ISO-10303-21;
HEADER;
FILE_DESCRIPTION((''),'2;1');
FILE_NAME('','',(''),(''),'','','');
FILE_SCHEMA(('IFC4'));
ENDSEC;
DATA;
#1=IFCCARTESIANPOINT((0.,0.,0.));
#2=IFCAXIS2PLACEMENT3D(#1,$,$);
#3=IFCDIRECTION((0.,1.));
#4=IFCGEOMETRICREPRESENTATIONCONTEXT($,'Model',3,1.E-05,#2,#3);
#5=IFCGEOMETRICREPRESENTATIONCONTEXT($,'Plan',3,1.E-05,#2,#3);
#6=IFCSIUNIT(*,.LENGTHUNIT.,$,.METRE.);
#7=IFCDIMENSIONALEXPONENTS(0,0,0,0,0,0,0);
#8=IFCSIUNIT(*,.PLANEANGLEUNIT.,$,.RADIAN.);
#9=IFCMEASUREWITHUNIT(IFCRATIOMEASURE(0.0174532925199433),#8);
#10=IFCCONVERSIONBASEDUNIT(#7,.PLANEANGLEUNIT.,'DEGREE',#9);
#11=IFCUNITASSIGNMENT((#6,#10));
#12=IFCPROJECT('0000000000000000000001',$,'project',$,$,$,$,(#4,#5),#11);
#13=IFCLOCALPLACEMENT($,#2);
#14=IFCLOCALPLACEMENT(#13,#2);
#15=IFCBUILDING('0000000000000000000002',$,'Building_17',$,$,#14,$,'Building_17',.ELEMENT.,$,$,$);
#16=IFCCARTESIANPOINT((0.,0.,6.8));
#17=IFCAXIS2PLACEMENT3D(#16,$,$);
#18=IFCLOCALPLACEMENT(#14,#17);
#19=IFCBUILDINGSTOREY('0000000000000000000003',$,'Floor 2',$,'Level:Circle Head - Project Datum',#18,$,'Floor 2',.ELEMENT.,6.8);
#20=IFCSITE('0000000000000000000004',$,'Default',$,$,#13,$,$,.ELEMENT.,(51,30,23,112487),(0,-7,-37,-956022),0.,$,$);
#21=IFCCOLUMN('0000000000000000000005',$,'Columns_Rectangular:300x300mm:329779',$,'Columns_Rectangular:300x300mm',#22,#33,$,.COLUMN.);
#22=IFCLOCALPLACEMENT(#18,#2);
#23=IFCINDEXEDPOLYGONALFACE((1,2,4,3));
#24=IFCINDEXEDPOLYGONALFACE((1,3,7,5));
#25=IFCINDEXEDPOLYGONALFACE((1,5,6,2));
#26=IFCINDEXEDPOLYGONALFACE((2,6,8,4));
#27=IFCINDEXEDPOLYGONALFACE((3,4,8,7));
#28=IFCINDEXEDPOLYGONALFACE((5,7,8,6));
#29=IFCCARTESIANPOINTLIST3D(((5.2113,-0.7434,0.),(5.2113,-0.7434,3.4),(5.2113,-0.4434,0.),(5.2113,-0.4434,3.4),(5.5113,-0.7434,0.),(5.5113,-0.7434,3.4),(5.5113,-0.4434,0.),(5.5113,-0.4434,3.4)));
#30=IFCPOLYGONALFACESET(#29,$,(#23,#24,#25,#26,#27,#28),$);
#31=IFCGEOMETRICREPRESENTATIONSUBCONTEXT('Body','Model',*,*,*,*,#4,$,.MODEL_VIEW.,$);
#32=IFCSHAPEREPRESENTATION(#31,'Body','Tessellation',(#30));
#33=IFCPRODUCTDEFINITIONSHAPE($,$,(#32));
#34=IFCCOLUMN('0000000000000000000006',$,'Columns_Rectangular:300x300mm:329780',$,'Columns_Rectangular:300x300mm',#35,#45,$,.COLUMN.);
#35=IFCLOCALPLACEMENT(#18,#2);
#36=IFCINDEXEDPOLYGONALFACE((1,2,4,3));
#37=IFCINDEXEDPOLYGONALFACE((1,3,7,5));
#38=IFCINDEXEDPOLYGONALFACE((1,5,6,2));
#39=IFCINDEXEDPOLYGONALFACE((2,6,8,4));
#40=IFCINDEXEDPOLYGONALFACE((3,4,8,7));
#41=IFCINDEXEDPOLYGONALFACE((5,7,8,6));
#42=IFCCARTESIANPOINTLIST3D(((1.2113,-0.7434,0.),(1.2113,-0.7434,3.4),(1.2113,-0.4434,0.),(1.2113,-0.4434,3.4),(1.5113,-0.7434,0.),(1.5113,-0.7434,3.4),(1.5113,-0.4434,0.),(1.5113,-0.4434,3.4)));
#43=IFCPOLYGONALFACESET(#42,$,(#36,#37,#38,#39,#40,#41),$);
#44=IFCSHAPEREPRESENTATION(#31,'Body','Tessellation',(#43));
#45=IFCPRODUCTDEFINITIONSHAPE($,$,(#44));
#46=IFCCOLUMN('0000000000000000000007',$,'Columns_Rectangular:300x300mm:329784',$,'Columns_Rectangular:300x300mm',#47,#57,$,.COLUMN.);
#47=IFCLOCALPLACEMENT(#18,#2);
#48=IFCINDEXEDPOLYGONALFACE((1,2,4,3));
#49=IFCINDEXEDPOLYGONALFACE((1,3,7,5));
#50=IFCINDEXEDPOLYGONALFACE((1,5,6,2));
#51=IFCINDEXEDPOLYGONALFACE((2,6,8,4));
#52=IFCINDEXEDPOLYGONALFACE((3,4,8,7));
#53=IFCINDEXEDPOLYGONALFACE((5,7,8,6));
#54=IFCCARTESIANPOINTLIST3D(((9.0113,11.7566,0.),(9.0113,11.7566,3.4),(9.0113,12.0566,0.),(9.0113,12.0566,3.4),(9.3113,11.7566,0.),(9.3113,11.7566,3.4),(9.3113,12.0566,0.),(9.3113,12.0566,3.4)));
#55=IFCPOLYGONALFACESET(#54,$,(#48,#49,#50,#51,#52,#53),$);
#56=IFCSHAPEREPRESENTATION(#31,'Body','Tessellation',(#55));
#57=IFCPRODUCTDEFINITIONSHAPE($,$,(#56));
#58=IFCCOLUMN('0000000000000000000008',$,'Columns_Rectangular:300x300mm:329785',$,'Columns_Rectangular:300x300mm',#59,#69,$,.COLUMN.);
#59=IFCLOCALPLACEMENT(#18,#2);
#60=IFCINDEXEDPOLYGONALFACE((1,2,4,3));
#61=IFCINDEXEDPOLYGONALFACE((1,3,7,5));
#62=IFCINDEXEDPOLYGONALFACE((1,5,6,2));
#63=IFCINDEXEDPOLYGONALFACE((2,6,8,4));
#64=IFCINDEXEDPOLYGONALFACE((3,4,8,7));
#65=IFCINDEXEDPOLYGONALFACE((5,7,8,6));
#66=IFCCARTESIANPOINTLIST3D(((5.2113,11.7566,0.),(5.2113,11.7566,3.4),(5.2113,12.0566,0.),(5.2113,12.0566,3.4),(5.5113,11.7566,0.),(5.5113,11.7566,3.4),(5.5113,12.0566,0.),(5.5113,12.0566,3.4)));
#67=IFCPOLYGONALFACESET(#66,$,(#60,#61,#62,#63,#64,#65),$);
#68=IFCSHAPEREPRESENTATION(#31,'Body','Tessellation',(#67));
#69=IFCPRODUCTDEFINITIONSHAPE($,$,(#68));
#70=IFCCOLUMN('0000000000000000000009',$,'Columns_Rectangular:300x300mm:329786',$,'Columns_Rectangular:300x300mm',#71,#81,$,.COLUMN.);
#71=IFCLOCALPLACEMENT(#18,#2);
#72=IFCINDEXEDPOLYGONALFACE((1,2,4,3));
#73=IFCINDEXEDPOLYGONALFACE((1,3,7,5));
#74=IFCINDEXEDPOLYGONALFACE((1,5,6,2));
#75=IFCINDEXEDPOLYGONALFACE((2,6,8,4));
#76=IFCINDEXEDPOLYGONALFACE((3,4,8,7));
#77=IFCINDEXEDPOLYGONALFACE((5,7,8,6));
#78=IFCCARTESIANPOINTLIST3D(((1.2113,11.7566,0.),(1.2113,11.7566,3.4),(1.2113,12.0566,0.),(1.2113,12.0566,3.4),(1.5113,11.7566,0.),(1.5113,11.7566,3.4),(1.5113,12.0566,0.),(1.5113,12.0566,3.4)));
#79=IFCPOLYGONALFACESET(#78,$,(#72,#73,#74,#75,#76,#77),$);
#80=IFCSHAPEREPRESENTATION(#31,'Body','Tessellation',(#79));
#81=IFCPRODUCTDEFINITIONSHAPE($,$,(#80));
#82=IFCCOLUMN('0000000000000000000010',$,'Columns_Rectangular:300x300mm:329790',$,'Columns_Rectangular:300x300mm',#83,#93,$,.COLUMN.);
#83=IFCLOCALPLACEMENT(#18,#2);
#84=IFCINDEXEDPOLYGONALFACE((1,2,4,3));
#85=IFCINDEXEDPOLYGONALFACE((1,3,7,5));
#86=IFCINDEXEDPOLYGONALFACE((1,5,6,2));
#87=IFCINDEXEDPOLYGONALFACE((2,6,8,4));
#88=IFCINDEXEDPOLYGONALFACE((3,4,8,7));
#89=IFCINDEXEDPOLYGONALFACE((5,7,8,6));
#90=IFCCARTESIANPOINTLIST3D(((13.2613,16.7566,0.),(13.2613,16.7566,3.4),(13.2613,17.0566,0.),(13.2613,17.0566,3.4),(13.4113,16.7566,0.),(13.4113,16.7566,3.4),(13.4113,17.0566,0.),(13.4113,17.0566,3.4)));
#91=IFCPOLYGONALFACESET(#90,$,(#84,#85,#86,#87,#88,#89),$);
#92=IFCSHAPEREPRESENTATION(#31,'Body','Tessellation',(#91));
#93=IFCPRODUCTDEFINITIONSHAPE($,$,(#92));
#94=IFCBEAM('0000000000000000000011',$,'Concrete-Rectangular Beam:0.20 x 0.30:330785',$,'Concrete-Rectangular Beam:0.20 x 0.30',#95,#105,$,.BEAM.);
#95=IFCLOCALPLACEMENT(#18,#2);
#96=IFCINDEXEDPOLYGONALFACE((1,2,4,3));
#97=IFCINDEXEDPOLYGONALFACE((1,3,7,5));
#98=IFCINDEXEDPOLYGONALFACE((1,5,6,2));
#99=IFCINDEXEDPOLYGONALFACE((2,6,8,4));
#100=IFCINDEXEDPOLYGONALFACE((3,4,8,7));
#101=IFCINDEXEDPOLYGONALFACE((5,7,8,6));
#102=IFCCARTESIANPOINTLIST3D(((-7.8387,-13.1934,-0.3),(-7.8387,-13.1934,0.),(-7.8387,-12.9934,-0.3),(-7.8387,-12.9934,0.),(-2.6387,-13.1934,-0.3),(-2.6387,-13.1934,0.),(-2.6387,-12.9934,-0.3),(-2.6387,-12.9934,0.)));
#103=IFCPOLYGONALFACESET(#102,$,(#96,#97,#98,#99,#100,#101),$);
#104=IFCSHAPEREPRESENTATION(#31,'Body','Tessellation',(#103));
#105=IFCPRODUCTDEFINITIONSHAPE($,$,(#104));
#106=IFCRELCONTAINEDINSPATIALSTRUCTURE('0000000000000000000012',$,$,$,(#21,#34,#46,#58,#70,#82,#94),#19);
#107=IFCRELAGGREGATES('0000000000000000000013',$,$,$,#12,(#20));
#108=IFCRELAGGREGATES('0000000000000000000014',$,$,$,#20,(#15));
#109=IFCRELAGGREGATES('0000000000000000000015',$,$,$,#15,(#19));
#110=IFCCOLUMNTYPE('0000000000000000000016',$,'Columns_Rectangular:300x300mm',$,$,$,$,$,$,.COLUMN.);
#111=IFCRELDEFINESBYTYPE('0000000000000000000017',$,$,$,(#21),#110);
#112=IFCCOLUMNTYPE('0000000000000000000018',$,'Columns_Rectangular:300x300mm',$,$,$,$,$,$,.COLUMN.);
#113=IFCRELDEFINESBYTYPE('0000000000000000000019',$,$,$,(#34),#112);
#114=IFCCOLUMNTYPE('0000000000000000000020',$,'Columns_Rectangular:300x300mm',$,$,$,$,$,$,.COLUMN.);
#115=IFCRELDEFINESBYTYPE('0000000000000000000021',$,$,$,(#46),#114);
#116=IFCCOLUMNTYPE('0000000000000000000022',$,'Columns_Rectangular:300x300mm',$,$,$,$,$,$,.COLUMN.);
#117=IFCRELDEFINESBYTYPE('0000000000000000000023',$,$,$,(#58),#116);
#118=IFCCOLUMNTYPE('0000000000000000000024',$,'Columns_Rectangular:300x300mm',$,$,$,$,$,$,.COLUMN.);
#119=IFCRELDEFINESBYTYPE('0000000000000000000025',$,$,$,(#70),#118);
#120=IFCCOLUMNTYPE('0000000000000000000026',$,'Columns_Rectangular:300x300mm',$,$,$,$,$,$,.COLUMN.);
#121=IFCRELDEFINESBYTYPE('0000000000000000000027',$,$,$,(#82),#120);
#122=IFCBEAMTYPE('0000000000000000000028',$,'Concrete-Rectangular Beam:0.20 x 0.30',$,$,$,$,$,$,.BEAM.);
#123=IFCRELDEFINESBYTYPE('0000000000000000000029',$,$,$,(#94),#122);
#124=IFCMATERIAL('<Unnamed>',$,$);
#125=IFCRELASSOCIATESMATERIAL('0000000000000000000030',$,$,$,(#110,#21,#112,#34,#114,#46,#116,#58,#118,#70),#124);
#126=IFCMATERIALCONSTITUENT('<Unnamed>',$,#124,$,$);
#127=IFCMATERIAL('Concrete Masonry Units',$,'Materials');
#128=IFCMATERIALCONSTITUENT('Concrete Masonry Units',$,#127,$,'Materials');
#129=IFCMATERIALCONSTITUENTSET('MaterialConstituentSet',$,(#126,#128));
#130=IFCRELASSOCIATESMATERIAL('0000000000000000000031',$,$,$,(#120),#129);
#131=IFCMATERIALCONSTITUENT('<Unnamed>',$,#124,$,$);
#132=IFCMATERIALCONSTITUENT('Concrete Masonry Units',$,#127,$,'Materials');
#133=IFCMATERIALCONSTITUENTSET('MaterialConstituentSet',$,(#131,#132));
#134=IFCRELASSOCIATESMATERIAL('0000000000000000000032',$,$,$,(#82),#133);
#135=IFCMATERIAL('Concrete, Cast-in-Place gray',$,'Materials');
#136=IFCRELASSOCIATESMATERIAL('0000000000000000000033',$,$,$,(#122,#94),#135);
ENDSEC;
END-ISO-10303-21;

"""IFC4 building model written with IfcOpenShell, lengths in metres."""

from ifc_helpers import new_model, entity, si_unit, converted_unit, direction, frame, origin, place, context, subcontext, project, spatial, indexed_curve, outline, extrude, source, transform, mapped, material, constituent, constituent_set, type_object, type_shapes, element, save


model = new_model("IFC4")

# Units and contexts
model_context = context("Model", 3, precision=1e-05, world=origin(), true_north=direction((0.0, 1.0)))
plan_context = context("Plan", 3, precision=1e-05, world=origin(), true_north=direction((0.0, 1.0)))
body_context = subcontext(model_context, "Body", "Model", "MODEL_VIEW")
ifc_project = project(units=[si_unit("LENGTHUNIT", "METRE"), converted_unit("PLANEANGLEUNIT", "DEGREE", entity("IfcRatioMeasure", 0.0174532925199433), si_unit("PLANEANGLEUNIT", "RADIAN"), dimensions=[0, 0, 0, 0, 0, 0, 0])], contexts=[model_context, plan_context])

# Site, building, storey
site_placement = place(None, origin())
site = spatial("IfcSite", under=ifc_project, at=site_placement, Name="Default", CompositionType="ELEMENT", RefLatitude=(51, 30, 23, 112487), RefLongitude=(0, -7, -37, -956022), RefElevation=0.0)
building_placement = place(site_placement, origin())
building = spatial("IfcBuilding", under=site, at=building_placement, Name="Building_17", LongName="Building_17", CompositionType="ELEMENT")
storey_placement = place(building_placement, frame((0.0, 0.0, 6.8)))
storey = spatial("IfcBuildingStorey", under=building, at=storey_placement, Name="Floor 2", ObjectType="Level:Circle Head - Project Datum", LongName="Floor 2", CompositionType="ELEMENT", Elevation=6.8)

# Columns
ifc_material_1 = material(Name="<Unnamed>")
ifc_material_2 = material(Name="Concrete Masonry Units", Category="Materials")
column_type_1 = type_object("IfcColumnType", Name="Columns_Rectangular:300x300mm", PredefinedType="COLUMN", material=ifc_material_1)
shared_shape_1 = source(origin(), body_context, "Body", "SweptSolid", [
    extrude(outline(indexed_curve([(-0.15, -0.15), (0.15, -0.15), (0.15, 0.15), (-0.15, 0.15), (-0.15, -0.15)], self_intersect=False)), frame((5.3613, -0.5934, 6.8), z_axis=(0.0, 0.0, 1.0), x_axis=(0.0, -1.0, 0.0)), (0.0, 0.0, 1.0), 3.4),
])
type_shapes(column_type_1, [shared_shape_1])
column_1_placement = place(storey_placement, frame((0.0, 0.0, -6.8)))
element("IfcColumn", 1, at=column_1_placement, inside=storey, type_object=column_type_1, material=ifc_material_1, Name="Columns_Rectangular:300x300mm:329779", ObjectType="Columns_Rectangular:300x300mm", PredefinedType="COLUMN", context=body_context, shape_type="MappedRepresentation", body=[
    mapped(shared_shape_1, transform((0.0, 0.0, 0.0), scale=1.0)),
])
column_type_2 = type_object("IfcColumnType", Name="Columns_Rectangular:300x300mm", PredefinedType="COLUMN", material=ifc_material_1)
shared_shape_2 = source(origin(), body_context, "Body", "SweptSolid", [
    extrude(outline(indexed_curve([(-0.15, -0.15), (0.15, -0.15), (0.15, 0.15), (-0.15, 0.15), (-0.15, -0.15)], self_intersect=False)), frame((1.3613, -0.5934, 6.8), z_axis=(0.0, 0.0, 1.0), x_axis=(0.0, -1.0, 0.0)), (0.0, 0.0, 1.0), 3.4),
])
type_shapes(column_type_2, [shared_shape_2])
column_2_placement = place(storey_placement, frame((0.0, 0.0, -6.8)))
element("IfcColumn", 2, at=column_2_placement, inside=storey, type_object=column_type_2, material=ifc_material_1, Name="Columns_Rectangular:300x300mm:329780", ObjectType="Columns_Rectangular:300x300mm", PredefinedType="COLUMN", context=body_context, shape_type="MappedRepresentation", body=[
    mapped(shared_shape_2, transform((0.0, 0.0, 0.0), scale=1.0)),
])
column_type_3 = type_object("IfcColumnType", Name="Columns_Rectangular:300x300mm", PredefinedType="COLUMN", material=ifc_material_1)
shared_shape_3 = source(origin(), body_context, "Body", "SweptSolid", [
    extrude(outline(indexed_curve([(-0.15, -0.15), (0.15, -0.15), (0.15, 0.15), (-0.15, 0.15), (-0.15, -0.15)], self_intersect=False)), frame((9.1613, 11.9066, 6.8), z_axis=(0.0, 0.0, 1.0), x_axis=(0.0, -1.0, 0.0)), (0.0, 0.0, 1.0), 3.4),
])
type_shapes(column_type_3, [shared_shape_3])
column_3_placement = place(storey_placement, frame((0.0, 0.0, -6.8)))
element("IfcColumn", 3, at=column_3_placement, inside=storey, type_object=column_type_3, material=ifc_material_1, Name="Columns_Rectangular:300x300mm:329784", ObjectType="Columns_Rectangular:300x300mm", PredefinedType="COLUMN", context=body_context, shape_type="MappedRepresentation", body=[
    mapped(shared_shape_3, transform((0.0, 0.0, 0.0), scale=1.0)),
])
column_type_4 = type_object("IfcColumnType", Name="Columns_Rectangular:300x300mm", PredefinedType="COLUMN", material=ifc_material_1)
shared_shape_4 = source(origin(), body_context, "Body", "SweptSolid", [
    extrude(outline(indexed_curve([(-0.15, -0.15), (0.15, -0.15), (0.15, 0.15), (-0.15, 0.15), (-0.15, -0.15)], self_intersect=False)), frame((5.3613, 11.9066, 6.8), z_axis=(0.0, 0.0, 1.0), x_axis=(0.0, -1.0, 0.0)), (0.0, 0.0, 1.0), 3.4),
])
type_shapes(column_type_4, [shared_shape_4])
column_4_placement = place(storey_placement, frame((0.0, 0.0, -6.8)))
element("IfcColumn", 4, at=column_4_placement, inside=storey, type_object=column_type_4, material=ifc_material_1, Name="Columns_Rectangular:300x300mm:329785", ObjectType="Columns_Rectangular:300x300mm", PredefinedType="COLUMN", context=body_context, shape_type="MappedRepresentation", body=[
    mapped(shared_shape_4, transform((0.0, 0.0, 0.0), scale=1.0)),
])
column_type_5 = type_object("IfcColumnType", Name="Columns_Rectangular:300x300mm", PredefinedType="COLUMN", material=ifc_material_1)
shared_shape_5 = source(origin(), body_context, "Body", "SweptSolid", [
    extrude(outline(indexed_curve([(-0.15, -0.15), (0.15, -0.15), (0.15, 0.15), (-0.15, 0.15), (-0.15, -0.15)], self_intersect=False)), frame((1.3613, 11.9066, 6.8), z_axis=(0.0, 0.0, 1.0), x_axis=(0.0, -1.0, 0.0)), (0.0, 0.0, 1.0), 3.4),
])
type_shapes(column_type_5, [shared_shape_5])
column_5_placement = place(storey_placement, frame((0.0, 0.0, -6.8)))
element("IfcColumn", 5, at=column_5_placement, inside=storey, type_object=column_type_5, material=ifc_material_1, Name="Columns_Rectangular:300x300mm:329786", ObjectType="Columns_Rectangular:300x300mm", PredefinedType="COLUMN", context=body_context, shape_type="MappedRepresentation", body=[
    mapped(shared_shape_5, transform((0.0, 0.0, 0.0), scale=1.0)),
])
ifc_constituent_1 = constituent(ifc_material_1, Name="<Unnamed>")
ifc_constituent_2 = constituent(ifc_material_2, Name="Concrete Masonry Units", Category="Materials")
ifc_constituent_set_1 = constituent_set(constituents=[ifc_constituent_1, ifc_constituent_2], Name="MaterialConstituentSet")
ifc_constituent_3 = constituent(ifc_material_1, Name="<Unnamed>")
ifc_constituent_4 = constituent(ifc_material_2, Name="Concrete Masonry Units", Category="Materials")
ifc_constituent_set_2 = constituent_set(constituents=[ifc_constituent_3, ifc_constituent_4], Name="MaterialConstituentSet")
column_type_6 = type_object("IfcColumnType", Name="Columns_Rectangular:300x300mm", PredefinedType="COLUMN", material=ifc_constituent_set_2)
shared_shape_6 = source(origin(), body_context, "Body", "SweptSolid", [
    extrude(outline(indexed_curve([(-0.15, -0.075), (0.15, -0.075), (0.15, 0.075), (-0.15, 0.075), (-0.15, -0.075)], self_intersect=False)), frame((13.3363, 16.9066, 6.8), z_axis=(0.0, 0.0, 1.0), x_axis=(0.0, -1.0, 0.0)), (0.0, 0.0, 1.0), 3.4),
])
type_shapes(column_type_6, [shared_shape_6])
column_6_placement = place(storey_placement, frame((0.0, 0.0, -6.8)))
element("IfcColumn", 6, at=column_6_placement, inside=storey, type_object=column_type_6, material=ifc_constituent_set_1, Name="Columns_Rectangular:300x300mm:329790", ObjectType="Columns_Rectangular:300x300mm", PredefinedType="COLUMN", context=body_context, shape_type="MappedRepresentation", body=[
    mapped(shared_shape_6, transform((0.0, 0.0, 0.0), scale=1.0)),
])

# Beam
ifc_material_3 = material(Name="Concrete, Cast-in-Place gray", Category="Materials")
beam_type = type_object("IfcBeamType", Name="Concrete-Rectangular Beam:0.20 x 0.30", PredefinedType="BEAM", material=ifc_material_3)
shared_shape_7 = source(origin(), body_context, "Body", "SweptSolid", [
    extrude(outline(indexed_curve([(-0.15, -0.1), (0.15, -0.1), (0.15, 0.1), (-0.15, 0.1), (-0.15, -0.1)], self_intersect=False)), frame((-7.8387, -13.0934, 6.65), z_axis=(1.0, 0.0, 0.0), x_axis=(0.0, 0.0, -1.0)), (0.0, 0.0, 1.0), 5.2),
])
type_shapes(beam_type, [shared_shape_7])
beam_placement = place(storey_placement, frame((0.0, 0.0, -6.8)))
element("IfcBeam", 7, at=beam_placement, inside=storey, type_object=beam_type, material=ifc_material_3, Name="Concrete-Rectangular Beam:0.20 x 0.30:330785", ObjectType="Concrete-Rectangular Beam:0.20 x 0.30", PredefinedType="BEAM", context=body_context, shape_type="MappedRepresentation", body=[
    mapped(shared_shape_7, transform((0.0, 0.0, 0.0), scale=1.0)),
])

save(model, "model.ifc")
